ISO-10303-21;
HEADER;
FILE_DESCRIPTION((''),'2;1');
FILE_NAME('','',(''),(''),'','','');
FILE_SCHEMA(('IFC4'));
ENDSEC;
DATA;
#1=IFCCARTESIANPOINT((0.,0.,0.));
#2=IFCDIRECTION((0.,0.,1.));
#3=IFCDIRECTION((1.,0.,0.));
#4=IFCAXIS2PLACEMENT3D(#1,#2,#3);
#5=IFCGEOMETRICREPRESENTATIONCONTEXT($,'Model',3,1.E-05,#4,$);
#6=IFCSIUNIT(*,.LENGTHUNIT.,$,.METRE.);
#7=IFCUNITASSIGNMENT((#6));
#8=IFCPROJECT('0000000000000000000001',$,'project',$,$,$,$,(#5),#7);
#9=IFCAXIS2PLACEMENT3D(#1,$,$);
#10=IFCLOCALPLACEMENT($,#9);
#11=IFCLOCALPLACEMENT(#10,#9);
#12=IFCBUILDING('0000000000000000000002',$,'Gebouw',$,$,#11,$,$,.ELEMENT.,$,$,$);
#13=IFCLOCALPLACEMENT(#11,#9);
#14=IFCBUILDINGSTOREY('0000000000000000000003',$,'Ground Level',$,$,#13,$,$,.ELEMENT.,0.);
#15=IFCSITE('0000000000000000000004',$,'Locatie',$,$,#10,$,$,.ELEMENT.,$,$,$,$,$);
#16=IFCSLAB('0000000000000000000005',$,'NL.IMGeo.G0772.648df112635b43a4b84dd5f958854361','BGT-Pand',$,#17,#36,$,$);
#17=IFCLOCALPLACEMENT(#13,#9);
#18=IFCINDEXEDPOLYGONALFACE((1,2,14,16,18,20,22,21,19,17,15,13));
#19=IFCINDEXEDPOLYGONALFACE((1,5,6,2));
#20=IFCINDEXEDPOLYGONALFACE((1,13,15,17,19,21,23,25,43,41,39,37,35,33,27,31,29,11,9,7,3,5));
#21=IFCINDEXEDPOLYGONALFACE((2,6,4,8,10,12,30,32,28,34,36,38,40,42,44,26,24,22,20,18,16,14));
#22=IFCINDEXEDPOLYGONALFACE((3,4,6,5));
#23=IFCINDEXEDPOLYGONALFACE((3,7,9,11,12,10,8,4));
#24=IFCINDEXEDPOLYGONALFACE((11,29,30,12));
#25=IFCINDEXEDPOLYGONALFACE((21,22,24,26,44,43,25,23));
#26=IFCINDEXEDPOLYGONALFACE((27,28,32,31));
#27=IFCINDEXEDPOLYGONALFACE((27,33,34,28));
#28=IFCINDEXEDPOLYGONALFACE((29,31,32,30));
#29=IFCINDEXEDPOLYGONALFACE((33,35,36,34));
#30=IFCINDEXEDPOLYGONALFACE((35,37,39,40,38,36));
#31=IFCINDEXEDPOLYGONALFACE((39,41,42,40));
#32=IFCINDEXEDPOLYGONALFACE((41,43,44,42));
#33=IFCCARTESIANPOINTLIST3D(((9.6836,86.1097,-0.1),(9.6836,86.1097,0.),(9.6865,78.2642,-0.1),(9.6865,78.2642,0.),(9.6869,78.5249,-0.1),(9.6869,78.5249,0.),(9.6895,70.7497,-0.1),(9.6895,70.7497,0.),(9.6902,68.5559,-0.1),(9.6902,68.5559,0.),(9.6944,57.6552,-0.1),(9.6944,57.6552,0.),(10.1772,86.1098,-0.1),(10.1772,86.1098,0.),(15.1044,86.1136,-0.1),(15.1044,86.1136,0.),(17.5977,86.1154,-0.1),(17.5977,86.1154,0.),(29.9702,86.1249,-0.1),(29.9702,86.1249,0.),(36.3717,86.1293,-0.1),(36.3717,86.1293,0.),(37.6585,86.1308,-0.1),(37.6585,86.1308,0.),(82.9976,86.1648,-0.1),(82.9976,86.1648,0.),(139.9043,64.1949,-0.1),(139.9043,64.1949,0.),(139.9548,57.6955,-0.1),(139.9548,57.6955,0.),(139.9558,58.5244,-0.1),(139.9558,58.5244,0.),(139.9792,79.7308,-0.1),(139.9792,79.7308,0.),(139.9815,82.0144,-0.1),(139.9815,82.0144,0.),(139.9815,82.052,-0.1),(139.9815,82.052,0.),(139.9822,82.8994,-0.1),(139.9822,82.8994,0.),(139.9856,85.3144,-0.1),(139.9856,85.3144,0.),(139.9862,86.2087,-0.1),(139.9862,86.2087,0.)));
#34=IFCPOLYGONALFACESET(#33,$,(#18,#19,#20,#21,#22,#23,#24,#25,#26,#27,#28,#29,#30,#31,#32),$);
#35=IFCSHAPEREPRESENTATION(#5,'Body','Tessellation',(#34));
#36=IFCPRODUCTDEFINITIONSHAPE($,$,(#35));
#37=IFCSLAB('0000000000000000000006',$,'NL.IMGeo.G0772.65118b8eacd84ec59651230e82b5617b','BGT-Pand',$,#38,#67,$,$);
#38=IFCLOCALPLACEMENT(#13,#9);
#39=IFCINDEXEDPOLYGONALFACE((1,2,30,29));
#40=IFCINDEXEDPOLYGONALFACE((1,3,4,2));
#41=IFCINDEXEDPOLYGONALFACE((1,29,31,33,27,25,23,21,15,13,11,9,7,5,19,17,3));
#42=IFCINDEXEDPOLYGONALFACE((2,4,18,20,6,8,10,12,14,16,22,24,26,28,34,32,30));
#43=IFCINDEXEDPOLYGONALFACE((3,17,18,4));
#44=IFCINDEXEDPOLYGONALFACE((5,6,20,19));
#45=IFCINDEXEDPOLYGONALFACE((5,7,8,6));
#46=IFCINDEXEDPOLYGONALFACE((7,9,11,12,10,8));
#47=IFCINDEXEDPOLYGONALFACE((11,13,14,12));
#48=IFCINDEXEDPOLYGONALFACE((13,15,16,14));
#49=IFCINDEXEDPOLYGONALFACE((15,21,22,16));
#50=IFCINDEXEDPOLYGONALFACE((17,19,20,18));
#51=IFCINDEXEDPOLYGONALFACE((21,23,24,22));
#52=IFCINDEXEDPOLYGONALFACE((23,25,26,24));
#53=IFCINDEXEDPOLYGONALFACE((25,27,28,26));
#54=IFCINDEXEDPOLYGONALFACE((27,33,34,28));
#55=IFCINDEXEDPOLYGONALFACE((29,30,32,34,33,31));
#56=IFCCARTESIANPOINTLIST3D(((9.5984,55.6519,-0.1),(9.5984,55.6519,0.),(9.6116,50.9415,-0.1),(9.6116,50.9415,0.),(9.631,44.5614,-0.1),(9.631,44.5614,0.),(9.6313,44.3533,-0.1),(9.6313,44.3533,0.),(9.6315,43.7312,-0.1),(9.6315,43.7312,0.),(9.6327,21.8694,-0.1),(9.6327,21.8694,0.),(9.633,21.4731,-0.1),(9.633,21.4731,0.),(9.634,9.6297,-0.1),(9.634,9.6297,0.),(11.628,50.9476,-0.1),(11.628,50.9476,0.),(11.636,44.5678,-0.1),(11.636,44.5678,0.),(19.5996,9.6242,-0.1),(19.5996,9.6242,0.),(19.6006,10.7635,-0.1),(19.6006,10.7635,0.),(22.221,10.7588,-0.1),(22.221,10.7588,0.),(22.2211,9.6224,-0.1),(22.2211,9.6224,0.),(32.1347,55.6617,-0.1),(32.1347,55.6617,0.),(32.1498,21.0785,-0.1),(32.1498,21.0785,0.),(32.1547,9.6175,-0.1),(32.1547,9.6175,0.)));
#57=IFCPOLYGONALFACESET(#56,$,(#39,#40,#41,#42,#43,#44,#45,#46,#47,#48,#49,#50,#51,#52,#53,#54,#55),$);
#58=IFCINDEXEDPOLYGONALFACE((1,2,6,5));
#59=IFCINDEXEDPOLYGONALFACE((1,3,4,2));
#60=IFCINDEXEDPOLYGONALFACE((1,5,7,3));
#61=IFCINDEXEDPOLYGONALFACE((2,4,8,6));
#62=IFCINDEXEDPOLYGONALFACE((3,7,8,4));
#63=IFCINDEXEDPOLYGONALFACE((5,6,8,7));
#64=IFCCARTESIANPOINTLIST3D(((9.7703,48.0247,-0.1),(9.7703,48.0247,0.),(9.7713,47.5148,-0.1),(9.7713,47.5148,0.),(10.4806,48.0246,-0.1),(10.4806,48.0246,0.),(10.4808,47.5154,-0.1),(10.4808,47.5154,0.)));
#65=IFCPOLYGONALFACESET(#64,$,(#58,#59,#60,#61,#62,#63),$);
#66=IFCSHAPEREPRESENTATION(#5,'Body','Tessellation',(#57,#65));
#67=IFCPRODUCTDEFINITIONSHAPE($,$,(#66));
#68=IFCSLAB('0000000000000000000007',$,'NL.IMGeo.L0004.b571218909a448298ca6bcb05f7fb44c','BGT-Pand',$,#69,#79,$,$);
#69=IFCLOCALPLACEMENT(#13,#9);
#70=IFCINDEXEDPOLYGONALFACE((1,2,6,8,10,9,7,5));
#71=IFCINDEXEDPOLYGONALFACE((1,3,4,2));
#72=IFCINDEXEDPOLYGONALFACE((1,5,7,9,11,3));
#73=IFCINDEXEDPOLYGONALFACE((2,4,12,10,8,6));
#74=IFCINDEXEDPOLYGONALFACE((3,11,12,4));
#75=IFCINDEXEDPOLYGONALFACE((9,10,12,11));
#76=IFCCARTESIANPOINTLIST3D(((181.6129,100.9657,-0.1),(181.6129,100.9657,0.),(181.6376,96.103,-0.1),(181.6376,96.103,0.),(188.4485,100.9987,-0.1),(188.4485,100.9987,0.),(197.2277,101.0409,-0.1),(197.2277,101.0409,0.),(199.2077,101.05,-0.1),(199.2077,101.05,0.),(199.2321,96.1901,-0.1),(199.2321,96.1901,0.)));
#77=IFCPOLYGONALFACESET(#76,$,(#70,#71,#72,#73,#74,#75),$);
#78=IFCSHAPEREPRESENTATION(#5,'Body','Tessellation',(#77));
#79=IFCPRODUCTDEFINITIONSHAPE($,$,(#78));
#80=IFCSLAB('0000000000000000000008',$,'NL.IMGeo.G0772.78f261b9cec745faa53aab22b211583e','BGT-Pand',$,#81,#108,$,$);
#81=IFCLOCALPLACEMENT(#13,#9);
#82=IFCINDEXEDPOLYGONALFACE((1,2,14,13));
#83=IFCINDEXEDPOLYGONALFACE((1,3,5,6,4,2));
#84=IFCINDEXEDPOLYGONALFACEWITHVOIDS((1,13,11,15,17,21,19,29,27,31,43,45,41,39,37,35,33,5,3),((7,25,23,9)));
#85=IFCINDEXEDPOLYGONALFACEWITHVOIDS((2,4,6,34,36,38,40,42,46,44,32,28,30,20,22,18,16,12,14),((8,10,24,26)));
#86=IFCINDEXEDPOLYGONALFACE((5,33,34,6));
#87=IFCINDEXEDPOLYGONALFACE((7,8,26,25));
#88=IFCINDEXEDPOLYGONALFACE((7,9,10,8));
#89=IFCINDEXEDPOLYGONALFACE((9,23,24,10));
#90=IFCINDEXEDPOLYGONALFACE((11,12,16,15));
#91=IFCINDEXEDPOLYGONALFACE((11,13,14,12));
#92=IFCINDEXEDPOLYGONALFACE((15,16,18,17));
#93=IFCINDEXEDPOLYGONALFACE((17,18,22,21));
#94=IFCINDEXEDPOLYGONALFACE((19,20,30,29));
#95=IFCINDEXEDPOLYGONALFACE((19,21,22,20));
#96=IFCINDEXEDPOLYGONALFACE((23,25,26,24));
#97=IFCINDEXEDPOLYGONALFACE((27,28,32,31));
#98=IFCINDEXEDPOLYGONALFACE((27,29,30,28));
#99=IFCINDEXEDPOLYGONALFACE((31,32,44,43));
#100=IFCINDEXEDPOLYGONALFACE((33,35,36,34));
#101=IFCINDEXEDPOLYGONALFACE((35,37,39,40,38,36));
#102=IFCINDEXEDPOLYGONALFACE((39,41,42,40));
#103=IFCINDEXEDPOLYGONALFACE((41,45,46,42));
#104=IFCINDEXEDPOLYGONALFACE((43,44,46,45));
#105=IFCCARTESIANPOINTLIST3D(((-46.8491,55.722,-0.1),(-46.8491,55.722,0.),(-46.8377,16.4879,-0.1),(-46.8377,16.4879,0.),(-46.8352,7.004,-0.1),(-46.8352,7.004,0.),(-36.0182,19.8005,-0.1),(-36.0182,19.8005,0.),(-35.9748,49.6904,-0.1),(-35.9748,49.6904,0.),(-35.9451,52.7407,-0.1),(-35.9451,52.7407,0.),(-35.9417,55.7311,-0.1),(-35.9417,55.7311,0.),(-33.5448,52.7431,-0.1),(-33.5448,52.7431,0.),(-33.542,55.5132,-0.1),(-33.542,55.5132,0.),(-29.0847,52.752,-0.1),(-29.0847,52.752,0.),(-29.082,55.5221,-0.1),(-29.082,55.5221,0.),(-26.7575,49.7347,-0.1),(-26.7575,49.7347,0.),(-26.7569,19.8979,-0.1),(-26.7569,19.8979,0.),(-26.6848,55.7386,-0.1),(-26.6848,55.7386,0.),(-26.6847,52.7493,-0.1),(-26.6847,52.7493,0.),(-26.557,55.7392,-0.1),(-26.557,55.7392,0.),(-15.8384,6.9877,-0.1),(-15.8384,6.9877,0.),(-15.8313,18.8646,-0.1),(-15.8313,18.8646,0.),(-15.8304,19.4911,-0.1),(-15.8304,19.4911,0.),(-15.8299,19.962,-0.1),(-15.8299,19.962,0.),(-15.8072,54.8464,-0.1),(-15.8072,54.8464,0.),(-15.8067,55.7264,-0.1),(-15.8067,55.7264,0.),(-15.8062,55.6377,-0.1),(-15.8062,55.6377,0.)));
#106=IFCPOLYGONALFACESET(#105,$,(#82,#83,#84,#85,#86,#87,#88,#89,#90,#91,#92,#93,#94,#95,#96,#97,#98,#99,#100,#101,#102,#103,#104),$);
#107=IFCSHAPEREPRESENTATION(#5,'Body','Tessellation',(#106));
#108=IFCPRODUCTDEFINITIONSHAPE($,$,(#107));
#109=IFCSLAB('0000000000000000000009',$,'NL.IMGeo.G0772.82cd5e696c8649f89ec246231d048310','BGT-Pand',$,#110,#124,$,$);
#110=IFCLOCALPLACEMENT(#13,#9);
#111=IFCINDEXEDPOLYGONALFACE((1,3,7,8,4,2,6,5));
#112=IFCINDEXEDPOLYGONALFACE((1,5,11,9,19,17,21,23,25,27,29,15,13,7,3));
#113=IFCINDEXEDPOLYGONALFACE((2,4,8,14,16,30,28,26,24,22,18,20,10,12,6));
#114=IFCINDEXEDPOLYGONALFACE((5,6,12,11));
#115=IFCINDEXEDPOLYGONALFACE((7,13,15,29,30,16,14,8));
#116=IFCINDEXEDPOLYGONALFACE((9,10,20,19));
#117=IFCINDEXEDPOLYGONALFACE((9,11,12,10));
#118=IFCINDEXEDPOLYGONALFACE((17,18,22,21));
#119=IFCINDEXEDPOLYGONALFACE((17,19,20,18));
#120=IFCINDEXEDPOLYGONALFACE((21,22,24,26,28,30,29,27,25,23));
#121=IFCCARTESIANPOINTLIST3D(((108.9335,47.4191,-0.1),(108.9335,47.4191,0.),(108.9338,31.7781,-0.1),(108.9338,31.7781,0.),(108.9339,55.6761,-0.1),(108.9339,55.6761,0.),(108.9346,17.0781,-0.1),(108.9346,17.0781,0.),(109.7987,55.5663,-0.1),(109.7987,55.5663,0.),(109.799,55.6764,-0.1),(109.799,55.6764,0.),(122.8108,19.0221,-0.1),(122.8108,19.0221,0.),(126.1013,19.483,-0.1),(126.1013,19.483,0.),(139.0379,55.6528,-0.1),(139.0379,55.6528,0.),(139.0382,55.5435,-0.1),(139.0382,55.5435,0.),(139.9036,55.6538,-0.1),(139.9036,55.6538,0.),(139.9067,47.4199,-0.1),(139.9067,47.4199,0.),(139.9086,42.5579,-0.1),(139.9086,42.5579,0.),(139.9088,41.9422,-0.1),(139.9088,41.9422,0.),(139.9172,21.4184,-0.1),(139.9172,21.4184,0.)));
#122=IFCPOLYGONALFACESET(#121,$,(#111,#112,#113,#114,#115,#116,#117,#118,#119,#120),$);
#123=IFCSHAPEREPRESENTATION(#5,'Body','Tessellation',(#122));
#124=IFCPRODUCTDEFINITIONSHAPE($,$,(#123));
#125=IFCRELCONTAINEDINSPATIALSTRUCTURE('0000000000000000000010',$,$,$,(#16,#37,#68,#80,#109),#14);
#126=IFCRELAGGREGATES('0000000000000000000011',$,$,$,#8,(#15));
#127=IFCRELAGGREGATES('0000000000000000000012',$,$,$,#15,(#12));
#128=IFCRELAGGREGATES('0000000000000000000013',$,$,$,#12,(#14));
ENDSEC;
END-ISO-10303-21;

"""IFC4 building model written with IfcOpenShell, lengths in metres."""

from ifc_helpers import new_model, si_unit, frame, origin, origin_with_axes, place, context, project, spatial, polyline, outline, extrude, element, save


model = new_model("IFC4")

# Units and contexts
model_context = context("Model", 3, precision=1e-05, world=origin_with_axes())
ifc_project = project(units=[si_unit("LENGTHUNIT", "METRE")], contexts=[model_context])

# Site, building, storey
site_placement = place(None, origin())
site = spatial("IfcSite", under=ifc_project, at=site_placement, Name="Locatie", CompositionType="ELEMENT")
building_placement = place(site_placement, origin())
building = spatial("IfcBuilding", under=site, at=building_placement, Name="Gebouw", CompositionType="ELEMENT")
storey_placement = place(building_placement, origin())
storey = spatial("IfcBuildingStorey", under=building, at=storey_placement, Name="Ground Level", CompositionType="ELEMENT", Elevation=0.0)

# Slabs
slab_1_placement = place(storey_placement, origin())
element("IfcSlab", 1, at=slab_1_placement, inside=storey, Name="NL.IMGeo.G0772.648df112635b43a4b84dd5f958854361", Description="BGT-Pand", context=model_context, shape_type="SweptSolid", body=[
    extrude(outline(polyline([(82.9976, 86.1648), (139.9862, 86.2087), (139.9856, 85.3144), (139.9822, 82.8994), (139.9815, 82.052), (139.9815, 82.0144), (139.9792, 79.7308), (139.9043, 64.1949), (139.9558, 58.5244), (139.9548, 57.6955), (9.6944, 57.6552), (9.6902, 68.5559), (9.6895, 70.7497), (9.6865, 78.2642), (9.6869, 78.5249), (9.6836, 86.1097), (10.1772, 86.1098), (15.1044, 86.1136), (17.5977, 86.1154), (29.9702, 86.1249), (36.3717, 86.1293), (37.6585, 86.1308), (82.9976, 86.1648)])), frame((0.0, 0.0, -0.1), z_axis=(0.0, 0.0, 1.0), x_axis=(1.0, 0.0, 0.0)), (0.0, 0.0, 1.0), 0.1),
])
slab_2_placement = place(storey_placement, origin())
element("IfcSlab", 2, at=slab_2_placement, inside=storey, Name="NL.IMGeo.G0772.65118b8eacd84ec59651230e82b5617b", Description="BGT-Pand", context=model_context, shape_type="SweptSolid", body=[
    extrude(outline(polyline([(32.1547, 9.6175), (22.2211, 9.6224), (22.221, 10.7588), (19.6006, 10.7635), (19.5996, 9.6242), (9.634, 9.6297), (9.633, 21.4731), (9.6327, 21.8694), (9.6315, 43.7312), (9.6313, 44.3533), (9.631, 44.5614), (11.636, 44.5678), (11.628, 50.9476), (9.6116, 50.9415), (9.5984, 55.6519), (32.1347, 55.6617), (32.1498, 21.0785), (32.1547, 9.6175)])), frame((0.0, 0.0, -0.1), z_axis=(0.0, 0.0, 1.0), x_axis=(1.0, 0.0, 0.0)), (0.0, 0.0, 1.0), 0.1),
    extrude(outline(polyline([(10.4808, 47.5154), (9.7713, 47.5148), (9.7703, 48.0247), (10.4806, 48.0246), (10.4808, 47.5154)])), frame((0.0, 0.0, -0.1), z_axis=(0.0, 0.0, 1.0), x_axis=(1.0, 0.0, 0.0)), (0.0, 0.0, 1.0), 0.1),
])
slab_3_placement = place(storey_placement, origin())
element("IfcSlab", 3, at=slab_3_placement, inside=storey, Name="NL.IMGeo.L0004.b571218909a448298ca6bcb05f7fb44c", Description="BGT-Pand", context=model_context, shape_type="SweptSolid", body=[
    extrude(outline(polyline([(181.6129, 100.9657), (188.4485, 100.9987), (197.2277, 101.0409), (199.2077, 101.05), (199.2321, 96.1901), (181.6376, 96.103), (181.6129, 100.9657)])), frame((0.0, 0.0, -0.1), z_axis=(0.0, 0.0, 1.0), x_axis=(1.0, 0.0, 0.0)), (0.0, 0.0, 1.0), 0.1),
])
slab_4_placement = place(storey_placement, origin())
element("IfcSlab", 4, at=slab_4_placement, inside=storey, Name="NL.IMGeo.G0772.78f261b9cec745faa53aab22b211583e", Description="BGT-Pand", context=model_context, shape_type="SweptSolid", body=[
    extrude(outline(polyline([(-15.8299, 19.962), (-15.8304, 19.4911), (-15.8313, 18.8646), (-15.8384, 6.9877), (-46.8352, 7.004), (-46.8377, 16.4879), (-46.8491, 55.722), (-35.9417, 55.7311), (-35.9451, 52.7407), (-33.5448, 52.7431), (-33.542, 55.5132), (-29.082, 55.5221), (-29.0847, 52.752), (-26.6847, 52.7493), (-26.6848, 55.7386), (-26.557, 55.7392), (-15.8067, 55.7264), (-15.8062, 55.6377), (-15.8072, 54.8464), (-15.8299, 19.962)]), holes=[polyline([(-26.7569, 19.8979), (-26.7575, 49.7347), (-35.9748, 49.6904), (-36.0182, 19.8005), (-26.7569, 19.8979)])]), frame((0.0, 0.0, -0.1), z_axis=(0.0, 0.0, 1.0), x_axis=(1.0, 0.0, 0.0)), (0.0, 0.0, 1.0), 0.1),
])
slab_5_placement = place(storey_placement, origin())
element("IfcSlab", 5, at=slab_5_placement, inside=storey, Name="NL.IMGeo.G0772.82cd5e696c8649f89ec246231d048310", Description="BGT-Pand", context=model_context, shape_type="SweptSolid", body=[
    extrude(outline(polyline([(139.0382, 55.5435), (139.0379, 55.6528), (139.9036, 55.6538), (139.9067, 47.4199), (139.9086, 42.5579), (139.9088, 41.9422), (139.9172, 21.4184), (126.1013, 19.483), (122.8108, 19.0221), (108.9346, 17.0781), (108.9338, 31.7781), (108.9335, 47.4191), (108.9339, 55.6761), (109.799, 55.6764), (109.7987, 55.5663), (139.0382, 55.5435)])), frame((0.0, 0.0, -0.1), z_axis=(0.0, 0.0, 1.0), x_axis=(1.0, 0.0, 0.0)), (0.0, 0.0, 1.0), 0.1),
])

save(model, "model.ifc")
